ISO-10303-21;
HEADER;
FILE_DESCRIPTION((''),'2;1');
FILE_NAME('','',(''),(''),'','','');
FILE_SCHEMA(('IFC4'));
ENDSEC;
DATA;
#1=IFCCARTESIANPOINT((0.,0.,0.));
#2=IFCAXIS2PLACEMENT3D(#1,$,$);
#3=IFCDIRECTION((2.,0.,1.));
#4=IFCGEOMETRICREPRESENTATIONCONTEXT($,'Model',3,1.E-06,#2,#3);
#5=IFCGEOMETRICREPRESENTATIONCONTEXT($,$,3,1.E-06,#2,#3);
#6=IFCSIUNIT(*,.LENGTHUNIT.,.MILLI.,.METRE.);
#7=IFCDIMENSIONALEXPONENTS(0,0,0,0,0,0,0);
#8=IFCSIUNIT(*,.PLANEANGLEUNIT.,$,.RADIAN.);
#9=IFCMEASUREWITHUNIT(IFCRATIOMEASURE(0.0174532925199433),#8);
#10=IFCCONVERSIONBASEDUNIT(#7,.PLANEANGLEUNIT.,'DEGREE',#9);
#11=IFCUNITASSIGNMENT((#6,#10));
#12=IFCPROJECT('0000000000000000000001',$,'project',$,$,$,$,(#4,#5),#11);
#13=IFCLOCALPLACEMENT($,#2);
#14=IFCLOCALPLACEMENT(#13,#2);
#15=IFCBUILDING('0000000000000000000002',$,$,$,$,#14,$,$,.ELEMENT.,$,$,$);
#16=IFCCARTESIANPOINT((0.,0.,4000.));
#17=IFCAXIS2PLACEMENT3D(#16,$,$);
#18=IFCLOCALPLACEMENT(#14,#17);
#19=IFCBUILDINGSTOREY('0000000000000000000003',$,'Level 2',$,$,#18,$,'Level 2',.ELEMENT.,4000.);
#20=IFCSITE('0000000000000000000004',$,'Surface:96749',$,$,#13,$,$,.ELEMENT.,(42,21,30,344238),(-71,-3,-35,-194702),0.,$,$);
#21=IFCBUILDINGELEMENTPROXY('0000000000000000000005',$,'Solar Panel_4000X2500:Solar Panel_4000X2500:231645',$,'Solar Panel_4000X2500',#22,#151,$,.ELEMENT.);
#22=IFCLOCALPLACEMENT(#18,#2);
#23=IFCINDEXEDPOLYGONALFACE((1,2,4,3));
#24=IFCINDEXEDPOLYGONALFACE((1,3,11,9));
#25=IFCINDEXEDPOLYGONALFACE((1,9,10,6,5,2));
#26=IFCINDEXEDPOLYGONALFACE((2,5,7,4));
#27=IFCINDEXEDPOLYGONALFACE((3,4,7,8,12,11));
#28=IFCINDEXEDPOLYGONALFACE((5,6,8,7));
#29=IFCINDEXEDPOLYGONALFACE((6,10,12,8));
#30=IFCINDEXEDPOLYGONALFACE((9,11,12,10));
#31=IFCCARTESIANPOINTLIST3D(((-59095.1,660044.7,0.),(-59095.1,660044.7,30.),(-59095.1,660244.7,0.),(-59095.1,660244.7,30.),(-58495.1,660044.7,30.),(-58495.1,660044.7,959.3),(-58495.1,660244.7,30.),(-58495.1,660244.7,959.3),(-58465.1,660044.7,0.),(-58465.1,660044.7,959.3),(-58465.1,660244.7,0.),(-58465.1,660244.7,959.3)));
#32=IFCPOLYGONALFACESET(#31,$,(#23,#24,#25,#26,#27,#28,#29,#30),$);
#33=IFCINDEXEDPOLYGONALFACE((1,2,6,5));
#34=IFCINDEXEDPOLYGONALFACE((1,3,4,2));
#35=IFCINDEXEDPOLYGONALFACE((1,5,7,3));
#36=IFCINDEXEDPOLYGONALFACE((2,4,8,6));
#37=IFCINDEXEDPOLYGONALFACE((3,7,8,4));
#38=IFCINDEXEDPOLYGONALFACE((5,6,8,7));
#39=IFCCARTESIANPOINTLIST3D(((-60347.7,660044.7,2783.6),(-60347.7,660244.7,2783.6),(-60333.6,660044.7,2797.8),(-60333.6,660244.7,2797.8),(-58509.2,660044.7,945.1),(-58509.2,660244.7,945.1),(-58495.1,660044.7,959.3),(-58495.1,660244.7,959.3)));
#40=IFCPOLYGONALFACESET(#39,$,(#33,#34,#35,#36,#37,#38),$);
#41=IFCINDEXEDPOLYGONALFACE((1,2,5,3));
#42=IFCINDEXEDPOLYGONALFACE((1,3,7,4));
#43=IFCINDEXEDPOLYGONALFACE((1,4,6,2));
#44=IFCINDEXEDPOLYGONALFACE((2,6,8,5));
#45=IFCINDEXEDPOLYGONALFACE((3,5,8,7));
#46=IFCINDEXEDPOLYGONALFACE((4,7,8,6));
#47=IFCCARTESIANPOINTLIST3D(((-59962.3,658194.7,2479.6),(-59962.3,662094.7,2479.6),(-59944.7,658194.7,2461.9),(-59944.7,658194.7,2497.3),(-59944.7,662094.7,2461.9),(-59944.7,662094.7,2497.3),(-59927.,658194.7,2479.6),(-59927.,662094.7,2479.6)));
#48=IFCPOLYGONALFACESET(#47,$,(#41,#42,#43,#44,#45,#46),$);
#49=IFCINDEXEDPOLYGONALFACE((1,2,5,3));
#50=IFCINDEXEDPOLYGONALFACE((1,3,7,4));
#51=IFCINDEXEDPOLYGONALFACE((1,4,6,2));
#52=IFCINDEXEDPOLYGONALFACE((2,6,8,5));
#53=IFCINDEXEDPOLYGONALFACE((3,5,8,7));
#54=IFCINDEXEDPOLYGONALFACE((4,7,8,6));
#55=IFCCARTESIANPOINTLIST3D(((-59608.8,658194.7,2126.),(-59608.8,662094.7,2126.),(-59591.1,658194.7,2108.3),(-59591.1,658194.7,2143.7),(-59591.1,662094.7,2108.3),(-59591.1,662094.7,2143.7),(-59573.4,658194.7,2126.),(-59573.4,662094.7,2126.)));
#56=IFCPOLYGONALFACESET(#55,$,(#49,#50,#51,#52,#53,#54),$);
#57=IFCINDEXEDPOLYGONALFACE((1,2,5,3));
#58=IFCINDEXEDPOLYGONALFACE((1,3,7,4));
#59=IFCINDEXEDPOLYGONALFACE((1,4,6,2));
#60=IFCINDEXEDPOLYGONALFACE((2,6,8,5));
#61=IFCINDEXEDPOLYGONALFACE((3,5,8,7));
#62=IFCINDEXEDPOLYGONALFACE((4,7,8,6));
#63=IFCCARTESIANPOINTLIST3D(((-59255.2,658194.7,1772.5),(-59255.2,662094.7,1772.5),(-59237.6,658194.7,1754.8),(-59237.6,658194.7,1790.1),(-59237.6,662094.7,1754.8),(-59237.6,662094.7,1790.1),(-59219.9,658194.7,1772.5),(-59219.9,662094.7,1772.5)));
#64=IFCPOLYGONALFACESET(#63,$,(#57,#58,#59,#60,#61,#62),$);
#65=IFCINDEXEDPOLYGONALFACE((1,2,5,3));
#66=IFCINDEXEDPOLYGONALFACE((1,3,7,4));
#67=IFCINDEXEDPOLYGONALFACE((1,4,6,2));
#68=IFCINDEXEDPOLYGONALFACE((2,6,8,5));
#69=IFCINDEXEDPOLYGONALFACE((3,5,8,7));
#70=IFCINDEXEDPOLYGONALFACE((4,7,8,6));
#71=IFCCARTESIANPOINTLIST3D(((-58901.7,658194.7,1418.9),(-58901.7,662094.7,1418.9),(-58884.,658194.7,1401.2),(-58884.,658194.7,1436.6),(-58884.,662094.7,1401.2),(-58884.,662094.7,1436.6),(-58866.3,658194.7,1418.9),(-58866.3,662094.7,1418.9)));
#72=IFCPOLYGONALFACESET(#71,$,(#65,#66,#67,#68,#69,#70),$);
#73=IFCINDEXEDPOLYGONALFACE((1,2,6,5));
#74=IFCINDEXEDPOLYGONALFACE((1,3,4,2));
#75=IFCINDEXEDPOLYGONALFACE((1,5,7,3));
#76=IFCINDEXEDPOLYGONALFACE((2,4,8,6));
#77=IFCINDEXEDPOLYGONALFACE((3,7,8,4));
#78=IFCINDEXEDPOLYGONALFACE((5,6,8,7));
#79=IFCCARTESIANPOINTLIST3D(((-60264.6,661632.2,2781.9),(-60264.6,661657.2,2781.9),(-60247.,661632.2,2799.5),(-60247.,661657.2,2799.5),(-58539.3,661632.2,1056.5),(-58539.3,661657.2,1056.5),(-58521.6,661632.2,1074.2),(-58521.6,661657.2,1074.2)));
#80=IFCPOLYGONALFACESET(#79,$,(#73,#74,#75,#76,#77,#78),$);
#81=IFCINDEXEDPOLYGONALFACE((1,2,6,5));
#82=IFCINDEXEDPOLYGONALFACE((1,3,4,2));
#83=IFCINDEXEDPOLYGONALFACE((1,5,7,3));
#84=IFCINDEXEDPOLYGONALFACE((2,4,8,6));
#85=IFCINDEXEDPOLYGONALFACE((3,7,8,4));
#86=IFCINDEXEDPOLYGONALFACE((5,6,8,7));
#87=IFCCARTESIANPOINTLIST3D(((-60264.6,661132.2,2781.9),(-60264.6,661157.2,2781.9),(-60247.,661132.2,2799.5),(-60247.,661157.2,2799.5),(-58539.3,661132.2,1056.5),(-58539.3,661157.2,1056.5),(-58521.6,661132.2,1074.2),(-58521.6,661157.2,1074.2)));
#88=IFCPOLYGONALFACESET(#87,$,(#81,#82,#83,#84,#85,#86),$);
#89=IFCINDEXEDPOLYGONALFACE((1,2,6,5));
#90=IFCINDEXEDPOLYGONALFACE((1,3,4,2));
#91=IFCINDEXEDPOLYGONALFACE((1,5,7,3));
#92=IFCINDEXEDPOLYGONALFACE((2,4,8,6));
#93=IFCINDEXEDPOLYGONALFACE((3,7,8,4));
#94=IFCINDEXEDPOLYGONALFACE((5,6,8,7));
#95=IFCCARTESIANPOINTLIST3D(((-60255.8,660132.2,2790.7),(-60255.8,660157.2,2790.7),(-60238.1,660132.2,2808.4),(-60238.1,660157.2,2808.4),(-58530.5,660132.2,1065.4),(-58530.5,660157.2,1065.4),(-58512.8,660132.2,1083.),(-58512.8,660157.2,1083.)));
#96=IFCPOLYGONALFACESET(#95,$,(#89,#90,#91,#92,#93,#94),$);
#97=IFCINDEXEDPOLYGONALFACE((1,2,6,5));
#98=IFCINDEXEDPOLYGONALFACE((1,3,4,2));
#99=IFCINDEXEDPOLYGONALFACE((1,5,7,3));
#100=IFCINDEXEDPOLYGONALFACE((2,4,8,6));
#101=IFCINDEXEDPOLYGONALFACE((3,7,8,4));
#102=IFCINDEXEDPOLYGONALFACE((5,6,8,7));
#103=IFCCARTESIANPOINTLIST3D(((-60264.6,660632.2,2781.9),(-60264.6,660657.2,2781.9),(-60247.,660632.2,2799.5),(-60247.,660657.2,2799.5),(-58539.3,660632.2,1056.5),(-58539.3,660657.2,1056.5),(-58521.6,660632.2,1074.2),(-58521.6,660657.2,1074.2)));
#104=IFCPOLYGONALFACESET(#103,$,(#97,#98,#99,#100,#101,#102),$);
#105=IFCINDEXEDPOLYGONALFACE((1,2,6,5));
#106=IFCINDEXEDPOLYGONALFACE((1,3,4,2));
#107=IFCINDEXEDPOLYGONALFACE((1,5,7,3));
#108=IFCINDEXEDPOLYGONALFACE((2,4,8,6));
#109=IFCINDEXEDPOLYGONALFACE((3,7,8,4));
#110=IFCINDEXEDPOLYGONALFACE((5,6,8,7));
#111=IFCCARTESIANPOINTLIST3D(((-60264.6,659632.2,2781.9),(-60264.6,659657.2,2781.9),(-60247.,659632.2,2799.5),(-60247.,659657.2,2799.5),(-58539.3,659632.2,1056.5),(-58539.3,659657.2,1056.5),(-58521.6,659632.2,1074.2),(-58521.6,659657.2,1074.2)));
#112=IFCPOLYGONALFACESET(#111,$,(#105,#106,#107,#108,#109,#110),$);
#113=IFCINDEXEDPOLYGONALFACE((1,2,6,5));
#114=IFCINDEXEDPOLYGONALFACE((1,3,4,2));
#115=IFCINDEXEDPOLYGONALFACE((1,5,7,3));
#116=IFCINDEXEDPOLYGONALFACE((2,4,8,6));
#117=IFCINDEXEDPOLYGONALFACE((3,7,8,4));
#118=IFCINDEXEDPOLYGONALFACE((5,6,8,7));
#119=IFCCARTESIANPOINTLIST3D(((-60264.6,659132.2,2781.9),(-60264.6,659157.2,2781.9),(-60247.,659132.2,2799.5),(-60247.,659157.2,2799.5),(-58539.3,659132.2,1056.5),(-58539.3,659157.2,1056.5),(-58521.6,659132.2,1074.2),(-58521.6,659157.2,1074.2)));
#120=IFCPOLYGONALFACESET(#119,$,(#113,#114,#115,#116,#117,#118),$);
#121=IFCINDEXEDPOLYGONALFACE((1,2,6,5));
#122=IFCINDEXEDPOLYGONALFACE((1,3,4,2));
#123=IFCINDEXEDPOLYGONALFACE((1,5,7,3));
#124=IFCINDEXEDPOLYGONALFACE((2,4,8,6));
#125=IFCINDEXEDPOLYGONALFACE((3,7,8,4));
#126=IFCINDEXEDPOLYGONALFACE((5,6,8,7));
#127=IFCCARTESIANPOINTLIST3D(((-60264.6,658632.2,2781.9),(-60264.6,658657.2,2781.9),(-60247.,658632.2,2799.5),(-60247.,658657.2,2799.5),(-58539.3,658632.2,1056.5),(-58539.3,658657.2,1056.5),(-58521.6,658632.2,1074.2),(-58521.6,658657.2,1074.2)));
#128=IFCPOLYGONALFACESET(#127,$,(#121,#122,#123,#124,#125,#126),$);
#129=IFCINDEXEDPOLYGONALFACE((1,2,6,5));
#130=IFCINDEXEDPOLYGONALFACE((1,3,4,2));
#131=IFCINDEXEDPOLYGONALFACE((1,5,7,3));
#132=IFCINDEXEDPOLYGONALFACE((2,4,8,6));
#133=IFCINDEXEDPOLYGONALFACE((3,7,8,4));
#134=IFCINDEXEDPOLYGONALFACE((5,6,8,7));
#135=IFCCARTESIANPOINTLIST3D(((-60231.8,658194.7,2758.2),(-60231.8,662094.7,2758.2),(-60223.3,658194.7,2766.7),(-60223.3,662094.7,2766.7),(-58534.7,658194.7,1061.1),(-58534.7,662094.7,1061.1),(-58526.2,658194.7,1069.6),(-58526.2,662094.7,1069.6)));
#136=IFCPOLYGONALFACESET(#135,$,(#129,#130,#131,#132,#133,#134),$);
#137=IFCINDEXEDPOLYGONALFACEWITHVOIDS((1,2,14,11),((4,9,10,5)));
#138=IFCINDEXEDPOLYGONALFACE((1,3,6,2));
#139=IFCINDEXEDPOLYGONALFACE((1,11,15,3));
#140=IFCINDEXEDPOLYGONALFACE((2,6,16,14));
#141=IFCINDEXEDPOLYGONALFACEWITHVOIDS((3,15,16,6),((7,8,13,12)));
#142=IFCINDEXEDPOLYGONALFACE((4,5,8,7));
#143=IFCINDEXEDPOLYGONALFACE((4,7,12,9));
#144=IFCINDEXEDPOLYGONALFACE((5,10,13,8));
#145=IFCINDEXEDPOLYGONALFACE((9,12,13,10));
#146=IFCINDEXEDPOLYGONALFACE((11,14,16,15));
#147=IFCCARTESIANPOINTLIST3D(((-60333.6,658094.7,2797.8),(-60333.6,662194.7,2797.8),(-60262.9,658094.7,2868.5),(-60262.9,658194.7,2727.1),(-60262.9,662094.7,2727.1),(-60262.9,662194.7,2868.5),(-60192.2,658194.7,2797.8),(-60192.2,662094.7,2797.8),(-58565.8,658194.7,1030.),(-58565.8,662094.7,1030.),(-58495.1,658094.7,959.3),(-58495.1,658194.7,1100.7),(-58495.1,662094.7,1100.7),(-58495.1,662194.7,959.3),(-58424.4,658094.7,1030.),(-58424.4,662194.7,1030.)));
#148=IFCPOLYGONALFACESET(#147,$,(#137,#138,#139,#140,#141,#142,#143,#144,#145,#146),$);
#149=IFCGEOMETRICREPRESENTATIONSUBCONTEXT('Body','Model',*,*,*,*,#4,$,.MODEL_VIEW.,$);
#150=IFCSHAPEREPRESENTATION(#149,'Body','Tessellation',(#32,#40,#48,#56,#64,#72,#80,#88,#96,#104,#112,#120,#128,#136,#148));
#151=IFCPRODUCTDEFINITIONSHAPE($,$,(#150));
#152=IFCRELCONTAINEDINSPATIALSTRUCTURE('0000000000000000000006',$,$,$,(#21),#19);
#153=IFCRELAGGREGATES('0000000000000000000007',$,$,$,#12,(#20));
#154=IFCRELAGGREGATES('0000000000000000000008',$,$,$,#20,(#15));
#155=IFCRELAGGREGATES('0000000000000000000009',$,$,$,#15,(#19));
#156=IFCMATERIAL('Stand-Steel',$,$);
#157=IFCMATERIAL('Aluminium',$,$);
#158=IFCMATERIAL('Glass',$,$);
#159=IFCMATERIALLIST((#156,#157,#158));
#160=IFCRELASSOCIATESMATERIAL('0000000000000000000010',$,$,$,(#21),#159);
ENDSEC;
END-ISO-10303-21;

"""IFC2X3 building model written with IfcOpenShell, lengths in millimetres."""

from ifc_helpers import new_model, entity, si_unit, converted_unit, direction, frame, frame_2d, origin, origin_2d_with_axis, place, context, subcontext, project, spatial, polyline, rectangle, outline, extrude, source, transform, mapped, material, material_list, element, save


model = new_model("IFC2X3")

# Units and contexts
model_context = context("Model", 3, precision=1e-06, world=origin(), true_north=direction((2.0, 0.0, 1.0)))
context_of_model = context(None, 3, precision=1e-06, world=origin(), true_north=direction((2.0, 0.0, 1.0)))
body_context = subcontext(model_context, "Body", "Model", "MODEL_VIEW")
ifc_project = project(units=[si_unit("LENGTHUNIT", "METRE", prefix="MILLI"), converted_unit("PLANEANGLEUNIT", "DEGREE", entity("IfcRatioMeasure", 0.0174532925199433), si_unit("PLANEANGLEUNIT", "RADIAN"), dimensions=[0, 0, 0, 0, 0, 0, 0])], contexts=[model_context, context_of_model])

# Site, building, storey
site_placement = place(None, origin())
site = spatial("IfcSite", under=ifc_project, at=site_placement, Name="Surface:96749", CompositionType="ELEMENT", RefLatitude=(42, 21, 30, 344238), RefLongitude=(-71, -3, -35, -194702), RefElevation=0.0)
building_placement = place(site_placement, origin())
building = spatial("IfcBuilding", under=site, at=building_placement, CompositionType="ELEMENT")
storey_placement = place(building_placement, frame((0.0, 0.0, 4000.0)))
storey = spatial("IfcBuildingStorey", under=building, at=storey_placement, Name="Level 2", LongName="Level 2", CompositionType="ELEMENT", Elevation=4000.0)

# Building element proxy
ifc_material_1 = material(Name="Stand-Steel")
ifc_material_2 = material(Name="Aluminium")
ifc_material_3 = material(Name="Glass")
shared_shape = source(origin(), body_context, "Body", "SweptSolid", [
    extrude(outline(polyline([(-629.5, -220.0), (329.8, -220.0), (329.8, 410.0), (299.8, 410.0), (299.8, -190.0), (-629.5, -190.0), (-629.5, -220.0)])), frame((-190.0, -100.0, 299.8), z_axis=(0.0, 1.0, 0.0), x_axis=(0.0, 0.0, -1.0)), (0.0, 0.0, 1.0), 200.0),
    extrude(rectangle(XDim=20.0, YDim=200.0, at=frame_2d((0.0, 0.0), x_axis=(0.0, 1.0))), frame((-7.1, 0.0, 922.2), z_axis=(-0.707107, 0.0, 0.707107), x_axis=(0.0, 1.0, 0.0)), (0.0, 0.0, 1.0), 2600.0),
    extrude(rectangle(XDim=25.0, YDim=25.0, at=frame_2d((0.0, 0.0), x_axis=(1.0, 0.0))), frame((-1449.6, -1950.0, 2449.6), z_axis=(0.0, 1.0, 0.0), x_axis=(-0.707107, 0.0, -0.707107)), (0.0, 0.0, 1.0), 3900.0),
    extrude(rectangle(XDim=25.0, YDim=25.0, at=origin_2d_with_axis()), frame((-1096.0, -1950.0, 2096.0), z_axis=(0.0, 1.0, 0.0), x_axis=(-0.707107, 0.0, -0.707107)), (0.0, 0.0, 1.0), 3900.0),
    extrude(rectangle(XDim=25.0, YDim=25.0, at=origin_2d_with_axis()), frame((-742.5, -1950.0, 1742.5), z_axis=(0.0, 1.0, 0.0), x_axis=(-0.707107, 0.0, -0.707107)), (0.0, 0.0, 1.0), 3900.0),
    extrude(rectangle(XDim=25.0, YDim=25.0, at=frame_2d((0.0, 0.0), x_axis=(1.0, 0.0))), frame((-388.9, -1950.0, 1388.9), z_axis=(0.0, 1.0, 0.0), x_axis=(-0.707107, 0.0, -0.707107)), (0.0, 0.0, 1.0), 3900.0),
    extrude(rectangle(XDim=25.0, YDim=25.0, at=frame_2d((0.0, 0.0), x_axis=(0.0, 1.0))), frame((-35.4, 1500.0, 1035.4), z_axis=(-0.707107, 0.0, 0.707107), x_axis=(0.0, 1.0, 0.0)), (0.0, 0.0, 1.0), 2440.0),
    extrude(rectangle(XDim=25.0, YDim=25.0, at=frame_2d((0.0, 0.0), x_axis=(0.0, 1.0))), frame((-35.4, 1000.0, 1035.4), z_axis=(-0.707107, 0.0, 0.707107), x_axis=(0.0, 1.0, 0.0)), (0.0, 0.0, 1.0), 2440.0),
    extrude(rectangle(XDim=25.0, YDim=25.0, at=frame_2d((0.0, 0.0), x_axis=(0.0, 1.0))), frame((-26.5, 0.0, 1044.2), z_axis=(-0.707107, 0.0, 0.707107), x_axis=(0.0, -1.0, 0.0)), (0.0, 0.0, 1.0), 2440.0),
    extrude(rectangle(XDim=25.0, YDim=25.0, at=frame_2d((0.0, 0.0), x_axis=(0.0, 1.0))), frame((-35.4, 500.0, 1035.4), z_axis=(-0.707107, 0.0, 0.707107), x_axis=(0.0, 1.0, 0.0)), (0.0, 0.0, 1.0), 2440.0),
    extrude(rectangle(XDim=25.0, YDim=25.0, at=frame_2d((0.0, 0.0), x_axis=(0.0, 1.0))), frame((-35.4, -500.0, 1035.4), z_axis=(-0.707107, 0.0, 0.707107), x_axis=(0.0, 1.0, 0.0)), (0.0, 0.0, 1.0), 2440.0),
    extrude(rectangle(XDim=25.0, YDim=25.0, at=frame_2d((0.0, 0.0), x_axis=(0.0, 1.0))), frame((-35.4, -1000.0, 1035.4), z_axis=(-0.707107, 0.0, 0.707107), x_axis=(0.0, 1.0, 0.0)), (0.0, 0.0, 1.0), 2440.0),
    extrude(rectangle(XDim=25.0, YDim=25.0, at=frame_2d((0.0, 0.0), x_axis=(0.0, 1.0))), frame((-35.4, -1500.0, 1035.4), z_axis=(-0.707107, 0.0, 0.707107), x_axis=(0.0, 1.0, 0.0)), (0.0, 0.0, 1.0), 2440.0),
    extrude(rectangle(XDim=2400.0, YDim=12.0, at=frame_2d((0.0, 0.0), x_axis=(1.0, 0.0))), frame((-883.9, -1950.0, 1883.9), z_axis=(0.0, 1.0, 0.0), x_axis=(0.707107, 0.0, -0.707107)), (0.0, 0.0, 1.0), 3900.0),
    extrude(outline(polyline([(-2050.0, -1300.0), (2050.0, -1300.0), (2050.0, 1300.0), (-2050.0, 1300.0), (-2050.0, -1300.0)]), holes=[polyline([(1950.0, -1200.0), (-1950.0, -1200.0), (-1950.0, 1200.0), (1950.0, 1200.0), (1950.0, -1200.0)])]), frame((-919.2, 0.0, 1848.5), z_axis=(0.707107, 0.0, 0.707107), x_axis=(0.0, 1.0, 0.0)), (0.0, 0.0, 1.0), 100.0),
])
ifc_material_list_1 = material_list([ifc_material_1, ifc_material_2, ifc_material_3])
proxy_1_placement = place(storey_placement, frame((-58495.1, 660144.7, 30.0)))
element("IfcBuildingElementProxy", 1, at=proxy_1_placement, inside=storey, material=ifc_material_list_1, Name="Solar Panel_4000X2500:Solar Panel_4000X2500:231645", ObjectType="Solar Panel_4000X2500", CompositionType="ELEMENT", context=body_context, shape_type="MappedRepresentation", body=[
    mapped(shared_shape, transform((0.0, 0.0, 0.0), scale=1.0)),
])

save(model, "model.ifc")
